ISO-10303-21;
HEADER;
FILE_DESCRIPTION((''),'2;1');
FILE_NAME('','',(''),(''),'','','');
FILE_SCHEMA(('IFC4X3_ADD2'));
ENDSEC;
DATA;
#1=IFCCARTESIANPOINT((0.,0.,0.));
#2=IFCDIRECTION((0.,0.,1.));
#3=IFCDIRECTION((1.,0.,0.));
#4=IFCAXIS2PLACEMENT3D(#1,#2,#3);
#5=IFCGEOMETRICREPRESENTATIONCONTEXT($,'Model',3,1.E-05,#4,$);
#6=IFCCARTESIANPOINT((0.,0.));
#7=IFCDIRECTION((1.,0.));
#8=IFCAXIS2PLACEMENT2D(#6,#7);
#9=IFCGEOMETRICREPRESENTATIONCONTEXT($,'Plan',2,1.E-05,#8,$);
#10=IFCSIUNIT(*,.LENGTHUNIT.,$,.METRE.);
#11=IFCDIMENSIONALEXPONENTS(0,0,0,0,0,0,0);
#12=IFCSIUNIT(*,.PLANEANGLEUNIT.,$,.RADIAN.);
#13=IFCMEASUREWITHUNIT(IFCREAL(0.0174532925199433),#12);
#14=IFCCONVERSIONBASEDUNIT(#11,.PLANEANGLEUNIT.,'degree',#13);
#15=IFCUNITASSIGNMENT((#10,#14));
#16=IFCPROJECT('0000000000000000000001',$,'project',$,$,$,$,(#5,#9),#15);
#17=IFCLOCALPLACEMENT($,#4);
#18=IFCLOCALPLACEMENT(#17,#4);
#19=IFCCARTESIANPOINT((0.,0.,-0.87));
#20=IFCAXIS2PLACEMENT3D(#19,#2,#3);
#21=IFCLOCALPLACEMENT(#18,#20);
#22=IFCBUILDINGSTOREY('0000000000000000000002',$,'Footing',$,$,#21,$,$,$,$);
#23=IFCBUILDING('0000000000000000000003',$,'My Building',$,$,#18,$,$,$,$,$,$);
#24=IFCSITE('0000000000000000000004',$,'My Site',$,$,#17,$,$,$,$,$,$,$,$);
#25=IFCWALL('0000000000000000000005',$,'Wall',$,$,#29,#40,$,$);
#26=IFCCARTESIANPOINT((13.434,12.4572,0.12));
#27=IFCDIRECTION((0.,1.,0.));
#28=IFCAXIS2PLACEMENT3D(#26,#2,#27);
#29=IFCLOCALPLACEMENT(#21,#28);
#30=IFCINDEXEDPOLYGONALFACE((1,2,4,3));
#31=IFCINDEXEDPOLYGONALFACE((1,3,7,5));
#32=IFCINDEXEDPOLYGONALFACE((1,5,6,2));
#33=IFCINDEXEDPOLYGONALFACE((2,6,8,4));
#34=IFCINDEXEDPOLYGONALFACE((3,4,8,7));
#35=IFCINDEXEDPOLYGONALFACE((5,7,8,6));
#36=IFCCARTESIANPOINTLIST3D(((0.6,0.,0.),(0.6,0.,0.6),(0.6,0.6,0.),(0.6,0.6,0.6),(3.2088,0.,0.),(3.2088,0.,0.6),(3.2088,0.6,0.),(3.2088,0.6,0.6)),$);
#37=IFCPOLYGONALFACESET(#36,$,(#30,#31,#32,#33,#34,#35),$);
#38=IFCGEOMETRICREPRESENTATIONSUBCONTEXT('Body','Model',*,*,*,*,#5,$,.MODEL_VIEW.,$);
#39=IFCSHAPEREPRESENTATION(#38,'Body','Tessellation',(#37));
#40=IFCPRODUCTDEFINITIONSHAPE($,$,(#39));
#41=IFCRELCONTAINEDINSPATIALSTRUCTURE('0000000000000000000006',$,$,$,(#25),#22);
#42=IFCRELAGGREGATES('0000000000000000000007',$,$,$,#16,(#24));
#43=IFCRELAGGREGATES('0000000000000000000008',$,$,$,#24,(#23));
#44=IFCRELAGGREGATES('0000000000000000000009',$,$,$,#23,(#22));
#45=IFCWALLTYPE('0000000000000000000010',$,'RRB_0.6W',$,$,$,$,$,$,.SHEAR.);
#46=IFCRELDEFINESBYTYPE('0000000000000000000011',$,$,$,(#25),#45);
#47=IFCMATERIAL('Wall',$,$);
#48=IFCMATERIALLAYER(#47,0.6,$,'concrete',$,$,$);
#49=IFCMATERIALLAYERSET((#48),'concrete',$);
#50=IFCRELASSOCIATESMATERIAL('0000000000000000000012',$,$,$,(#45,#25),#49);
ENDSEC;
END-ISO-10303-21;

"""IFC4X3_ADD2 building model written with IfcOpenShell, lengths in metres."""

from ifc_helpers import new_model, entity, si_unit, converted_unit, frame, origin_with_axes, origin_2d_with_axis, place, context, subcontext, project, spatial, line, indexed_curve, outline, extrude, material, layer, layer_set, layer_usage, type_object, element, save


model = new_model("IFC4X3_ADD2")

# Units and contexts
model_context = context("Model", 3, precision=1e-05, world=origin_with_axes())
plan_context = context("Plan", 2, precision=1e-05, world=origin_2d_with_axis())
body_context = subcontext(model_context, "Body", "Model", "MODEL_VIEW")
ifc_project = project(units=[si_unit("LENGTHUNIT", "METRE"), converted_unit("PLANEANGLEUNIT", "degree", entity("IfcReal", 0.0174532925199433), si_unit("PLANEANGLEUNIT", "RADIAN"), dimensions=[0, 0, 0, 0, 0, 0, 0])], contexts=[model_context, plan_context])

# Site, building, storey
site_placement = place(None, origin_with_axes())
site = spatial("IfcSite", under=ifc_project, at=site_placement, Name="My Site")
building_placement = place(site_placement, origin_with_axes())
building = spatial("IfcBuilding", under=site, at=building_placement, Name="My Building")
storey_placement = place(building_placement, frame((0.0, 0.0, -0.87), z_axis=(0.0, 0.0, 1.0), x_axis=(1.0, 0.0, 0.0)))
storey = spatial("IfcBuildingStorey", under=building, at=storey_placement, Name="Footing")

# Wall
ifc_material_1 = material(Name="Wall")
ifc_layer_1 = layer(ifc_material_1, 0.6, Name="concrete")
ifc_layer_set_1 = layer_set([ifc_layer_1], Name="concrete")
wall_type_1 = type_object("IfcWallType", Name="RRB_0.6W", PredefinedType="SHEAR", material=ifc_layer_set_1)
ifc_layer_usage_1 = layer_usage(ifc_layer_set_1, "AXIS2", "POSITIVE", 0.0)
wall_1_placement = place(storey_placement, frame((13.434, 12.4572, 0.12), z_axis=(0.0, 0.0, 1.0), x_axis=(0.0, 1.0, 0.0)))
element("IfcWall", 1, at=wall_1_placement, inside=storey, type_object=wall_type_1, material=ifc_layer_usage_1, Name="Wall", context=body_context, shape_type="SweptSolid", body=[
    extrude(outline(indexed_curve([(0.6, 0.0), (0.6, 0.6), (3.2088, 0.6), (3.2088, 0.0)], segments=[line(1, 2, 3, 4, 1)])), origin_with_axes(), (0.0, 0.0, 1.0), 0.6),
])

save(model, "model.ifc")
